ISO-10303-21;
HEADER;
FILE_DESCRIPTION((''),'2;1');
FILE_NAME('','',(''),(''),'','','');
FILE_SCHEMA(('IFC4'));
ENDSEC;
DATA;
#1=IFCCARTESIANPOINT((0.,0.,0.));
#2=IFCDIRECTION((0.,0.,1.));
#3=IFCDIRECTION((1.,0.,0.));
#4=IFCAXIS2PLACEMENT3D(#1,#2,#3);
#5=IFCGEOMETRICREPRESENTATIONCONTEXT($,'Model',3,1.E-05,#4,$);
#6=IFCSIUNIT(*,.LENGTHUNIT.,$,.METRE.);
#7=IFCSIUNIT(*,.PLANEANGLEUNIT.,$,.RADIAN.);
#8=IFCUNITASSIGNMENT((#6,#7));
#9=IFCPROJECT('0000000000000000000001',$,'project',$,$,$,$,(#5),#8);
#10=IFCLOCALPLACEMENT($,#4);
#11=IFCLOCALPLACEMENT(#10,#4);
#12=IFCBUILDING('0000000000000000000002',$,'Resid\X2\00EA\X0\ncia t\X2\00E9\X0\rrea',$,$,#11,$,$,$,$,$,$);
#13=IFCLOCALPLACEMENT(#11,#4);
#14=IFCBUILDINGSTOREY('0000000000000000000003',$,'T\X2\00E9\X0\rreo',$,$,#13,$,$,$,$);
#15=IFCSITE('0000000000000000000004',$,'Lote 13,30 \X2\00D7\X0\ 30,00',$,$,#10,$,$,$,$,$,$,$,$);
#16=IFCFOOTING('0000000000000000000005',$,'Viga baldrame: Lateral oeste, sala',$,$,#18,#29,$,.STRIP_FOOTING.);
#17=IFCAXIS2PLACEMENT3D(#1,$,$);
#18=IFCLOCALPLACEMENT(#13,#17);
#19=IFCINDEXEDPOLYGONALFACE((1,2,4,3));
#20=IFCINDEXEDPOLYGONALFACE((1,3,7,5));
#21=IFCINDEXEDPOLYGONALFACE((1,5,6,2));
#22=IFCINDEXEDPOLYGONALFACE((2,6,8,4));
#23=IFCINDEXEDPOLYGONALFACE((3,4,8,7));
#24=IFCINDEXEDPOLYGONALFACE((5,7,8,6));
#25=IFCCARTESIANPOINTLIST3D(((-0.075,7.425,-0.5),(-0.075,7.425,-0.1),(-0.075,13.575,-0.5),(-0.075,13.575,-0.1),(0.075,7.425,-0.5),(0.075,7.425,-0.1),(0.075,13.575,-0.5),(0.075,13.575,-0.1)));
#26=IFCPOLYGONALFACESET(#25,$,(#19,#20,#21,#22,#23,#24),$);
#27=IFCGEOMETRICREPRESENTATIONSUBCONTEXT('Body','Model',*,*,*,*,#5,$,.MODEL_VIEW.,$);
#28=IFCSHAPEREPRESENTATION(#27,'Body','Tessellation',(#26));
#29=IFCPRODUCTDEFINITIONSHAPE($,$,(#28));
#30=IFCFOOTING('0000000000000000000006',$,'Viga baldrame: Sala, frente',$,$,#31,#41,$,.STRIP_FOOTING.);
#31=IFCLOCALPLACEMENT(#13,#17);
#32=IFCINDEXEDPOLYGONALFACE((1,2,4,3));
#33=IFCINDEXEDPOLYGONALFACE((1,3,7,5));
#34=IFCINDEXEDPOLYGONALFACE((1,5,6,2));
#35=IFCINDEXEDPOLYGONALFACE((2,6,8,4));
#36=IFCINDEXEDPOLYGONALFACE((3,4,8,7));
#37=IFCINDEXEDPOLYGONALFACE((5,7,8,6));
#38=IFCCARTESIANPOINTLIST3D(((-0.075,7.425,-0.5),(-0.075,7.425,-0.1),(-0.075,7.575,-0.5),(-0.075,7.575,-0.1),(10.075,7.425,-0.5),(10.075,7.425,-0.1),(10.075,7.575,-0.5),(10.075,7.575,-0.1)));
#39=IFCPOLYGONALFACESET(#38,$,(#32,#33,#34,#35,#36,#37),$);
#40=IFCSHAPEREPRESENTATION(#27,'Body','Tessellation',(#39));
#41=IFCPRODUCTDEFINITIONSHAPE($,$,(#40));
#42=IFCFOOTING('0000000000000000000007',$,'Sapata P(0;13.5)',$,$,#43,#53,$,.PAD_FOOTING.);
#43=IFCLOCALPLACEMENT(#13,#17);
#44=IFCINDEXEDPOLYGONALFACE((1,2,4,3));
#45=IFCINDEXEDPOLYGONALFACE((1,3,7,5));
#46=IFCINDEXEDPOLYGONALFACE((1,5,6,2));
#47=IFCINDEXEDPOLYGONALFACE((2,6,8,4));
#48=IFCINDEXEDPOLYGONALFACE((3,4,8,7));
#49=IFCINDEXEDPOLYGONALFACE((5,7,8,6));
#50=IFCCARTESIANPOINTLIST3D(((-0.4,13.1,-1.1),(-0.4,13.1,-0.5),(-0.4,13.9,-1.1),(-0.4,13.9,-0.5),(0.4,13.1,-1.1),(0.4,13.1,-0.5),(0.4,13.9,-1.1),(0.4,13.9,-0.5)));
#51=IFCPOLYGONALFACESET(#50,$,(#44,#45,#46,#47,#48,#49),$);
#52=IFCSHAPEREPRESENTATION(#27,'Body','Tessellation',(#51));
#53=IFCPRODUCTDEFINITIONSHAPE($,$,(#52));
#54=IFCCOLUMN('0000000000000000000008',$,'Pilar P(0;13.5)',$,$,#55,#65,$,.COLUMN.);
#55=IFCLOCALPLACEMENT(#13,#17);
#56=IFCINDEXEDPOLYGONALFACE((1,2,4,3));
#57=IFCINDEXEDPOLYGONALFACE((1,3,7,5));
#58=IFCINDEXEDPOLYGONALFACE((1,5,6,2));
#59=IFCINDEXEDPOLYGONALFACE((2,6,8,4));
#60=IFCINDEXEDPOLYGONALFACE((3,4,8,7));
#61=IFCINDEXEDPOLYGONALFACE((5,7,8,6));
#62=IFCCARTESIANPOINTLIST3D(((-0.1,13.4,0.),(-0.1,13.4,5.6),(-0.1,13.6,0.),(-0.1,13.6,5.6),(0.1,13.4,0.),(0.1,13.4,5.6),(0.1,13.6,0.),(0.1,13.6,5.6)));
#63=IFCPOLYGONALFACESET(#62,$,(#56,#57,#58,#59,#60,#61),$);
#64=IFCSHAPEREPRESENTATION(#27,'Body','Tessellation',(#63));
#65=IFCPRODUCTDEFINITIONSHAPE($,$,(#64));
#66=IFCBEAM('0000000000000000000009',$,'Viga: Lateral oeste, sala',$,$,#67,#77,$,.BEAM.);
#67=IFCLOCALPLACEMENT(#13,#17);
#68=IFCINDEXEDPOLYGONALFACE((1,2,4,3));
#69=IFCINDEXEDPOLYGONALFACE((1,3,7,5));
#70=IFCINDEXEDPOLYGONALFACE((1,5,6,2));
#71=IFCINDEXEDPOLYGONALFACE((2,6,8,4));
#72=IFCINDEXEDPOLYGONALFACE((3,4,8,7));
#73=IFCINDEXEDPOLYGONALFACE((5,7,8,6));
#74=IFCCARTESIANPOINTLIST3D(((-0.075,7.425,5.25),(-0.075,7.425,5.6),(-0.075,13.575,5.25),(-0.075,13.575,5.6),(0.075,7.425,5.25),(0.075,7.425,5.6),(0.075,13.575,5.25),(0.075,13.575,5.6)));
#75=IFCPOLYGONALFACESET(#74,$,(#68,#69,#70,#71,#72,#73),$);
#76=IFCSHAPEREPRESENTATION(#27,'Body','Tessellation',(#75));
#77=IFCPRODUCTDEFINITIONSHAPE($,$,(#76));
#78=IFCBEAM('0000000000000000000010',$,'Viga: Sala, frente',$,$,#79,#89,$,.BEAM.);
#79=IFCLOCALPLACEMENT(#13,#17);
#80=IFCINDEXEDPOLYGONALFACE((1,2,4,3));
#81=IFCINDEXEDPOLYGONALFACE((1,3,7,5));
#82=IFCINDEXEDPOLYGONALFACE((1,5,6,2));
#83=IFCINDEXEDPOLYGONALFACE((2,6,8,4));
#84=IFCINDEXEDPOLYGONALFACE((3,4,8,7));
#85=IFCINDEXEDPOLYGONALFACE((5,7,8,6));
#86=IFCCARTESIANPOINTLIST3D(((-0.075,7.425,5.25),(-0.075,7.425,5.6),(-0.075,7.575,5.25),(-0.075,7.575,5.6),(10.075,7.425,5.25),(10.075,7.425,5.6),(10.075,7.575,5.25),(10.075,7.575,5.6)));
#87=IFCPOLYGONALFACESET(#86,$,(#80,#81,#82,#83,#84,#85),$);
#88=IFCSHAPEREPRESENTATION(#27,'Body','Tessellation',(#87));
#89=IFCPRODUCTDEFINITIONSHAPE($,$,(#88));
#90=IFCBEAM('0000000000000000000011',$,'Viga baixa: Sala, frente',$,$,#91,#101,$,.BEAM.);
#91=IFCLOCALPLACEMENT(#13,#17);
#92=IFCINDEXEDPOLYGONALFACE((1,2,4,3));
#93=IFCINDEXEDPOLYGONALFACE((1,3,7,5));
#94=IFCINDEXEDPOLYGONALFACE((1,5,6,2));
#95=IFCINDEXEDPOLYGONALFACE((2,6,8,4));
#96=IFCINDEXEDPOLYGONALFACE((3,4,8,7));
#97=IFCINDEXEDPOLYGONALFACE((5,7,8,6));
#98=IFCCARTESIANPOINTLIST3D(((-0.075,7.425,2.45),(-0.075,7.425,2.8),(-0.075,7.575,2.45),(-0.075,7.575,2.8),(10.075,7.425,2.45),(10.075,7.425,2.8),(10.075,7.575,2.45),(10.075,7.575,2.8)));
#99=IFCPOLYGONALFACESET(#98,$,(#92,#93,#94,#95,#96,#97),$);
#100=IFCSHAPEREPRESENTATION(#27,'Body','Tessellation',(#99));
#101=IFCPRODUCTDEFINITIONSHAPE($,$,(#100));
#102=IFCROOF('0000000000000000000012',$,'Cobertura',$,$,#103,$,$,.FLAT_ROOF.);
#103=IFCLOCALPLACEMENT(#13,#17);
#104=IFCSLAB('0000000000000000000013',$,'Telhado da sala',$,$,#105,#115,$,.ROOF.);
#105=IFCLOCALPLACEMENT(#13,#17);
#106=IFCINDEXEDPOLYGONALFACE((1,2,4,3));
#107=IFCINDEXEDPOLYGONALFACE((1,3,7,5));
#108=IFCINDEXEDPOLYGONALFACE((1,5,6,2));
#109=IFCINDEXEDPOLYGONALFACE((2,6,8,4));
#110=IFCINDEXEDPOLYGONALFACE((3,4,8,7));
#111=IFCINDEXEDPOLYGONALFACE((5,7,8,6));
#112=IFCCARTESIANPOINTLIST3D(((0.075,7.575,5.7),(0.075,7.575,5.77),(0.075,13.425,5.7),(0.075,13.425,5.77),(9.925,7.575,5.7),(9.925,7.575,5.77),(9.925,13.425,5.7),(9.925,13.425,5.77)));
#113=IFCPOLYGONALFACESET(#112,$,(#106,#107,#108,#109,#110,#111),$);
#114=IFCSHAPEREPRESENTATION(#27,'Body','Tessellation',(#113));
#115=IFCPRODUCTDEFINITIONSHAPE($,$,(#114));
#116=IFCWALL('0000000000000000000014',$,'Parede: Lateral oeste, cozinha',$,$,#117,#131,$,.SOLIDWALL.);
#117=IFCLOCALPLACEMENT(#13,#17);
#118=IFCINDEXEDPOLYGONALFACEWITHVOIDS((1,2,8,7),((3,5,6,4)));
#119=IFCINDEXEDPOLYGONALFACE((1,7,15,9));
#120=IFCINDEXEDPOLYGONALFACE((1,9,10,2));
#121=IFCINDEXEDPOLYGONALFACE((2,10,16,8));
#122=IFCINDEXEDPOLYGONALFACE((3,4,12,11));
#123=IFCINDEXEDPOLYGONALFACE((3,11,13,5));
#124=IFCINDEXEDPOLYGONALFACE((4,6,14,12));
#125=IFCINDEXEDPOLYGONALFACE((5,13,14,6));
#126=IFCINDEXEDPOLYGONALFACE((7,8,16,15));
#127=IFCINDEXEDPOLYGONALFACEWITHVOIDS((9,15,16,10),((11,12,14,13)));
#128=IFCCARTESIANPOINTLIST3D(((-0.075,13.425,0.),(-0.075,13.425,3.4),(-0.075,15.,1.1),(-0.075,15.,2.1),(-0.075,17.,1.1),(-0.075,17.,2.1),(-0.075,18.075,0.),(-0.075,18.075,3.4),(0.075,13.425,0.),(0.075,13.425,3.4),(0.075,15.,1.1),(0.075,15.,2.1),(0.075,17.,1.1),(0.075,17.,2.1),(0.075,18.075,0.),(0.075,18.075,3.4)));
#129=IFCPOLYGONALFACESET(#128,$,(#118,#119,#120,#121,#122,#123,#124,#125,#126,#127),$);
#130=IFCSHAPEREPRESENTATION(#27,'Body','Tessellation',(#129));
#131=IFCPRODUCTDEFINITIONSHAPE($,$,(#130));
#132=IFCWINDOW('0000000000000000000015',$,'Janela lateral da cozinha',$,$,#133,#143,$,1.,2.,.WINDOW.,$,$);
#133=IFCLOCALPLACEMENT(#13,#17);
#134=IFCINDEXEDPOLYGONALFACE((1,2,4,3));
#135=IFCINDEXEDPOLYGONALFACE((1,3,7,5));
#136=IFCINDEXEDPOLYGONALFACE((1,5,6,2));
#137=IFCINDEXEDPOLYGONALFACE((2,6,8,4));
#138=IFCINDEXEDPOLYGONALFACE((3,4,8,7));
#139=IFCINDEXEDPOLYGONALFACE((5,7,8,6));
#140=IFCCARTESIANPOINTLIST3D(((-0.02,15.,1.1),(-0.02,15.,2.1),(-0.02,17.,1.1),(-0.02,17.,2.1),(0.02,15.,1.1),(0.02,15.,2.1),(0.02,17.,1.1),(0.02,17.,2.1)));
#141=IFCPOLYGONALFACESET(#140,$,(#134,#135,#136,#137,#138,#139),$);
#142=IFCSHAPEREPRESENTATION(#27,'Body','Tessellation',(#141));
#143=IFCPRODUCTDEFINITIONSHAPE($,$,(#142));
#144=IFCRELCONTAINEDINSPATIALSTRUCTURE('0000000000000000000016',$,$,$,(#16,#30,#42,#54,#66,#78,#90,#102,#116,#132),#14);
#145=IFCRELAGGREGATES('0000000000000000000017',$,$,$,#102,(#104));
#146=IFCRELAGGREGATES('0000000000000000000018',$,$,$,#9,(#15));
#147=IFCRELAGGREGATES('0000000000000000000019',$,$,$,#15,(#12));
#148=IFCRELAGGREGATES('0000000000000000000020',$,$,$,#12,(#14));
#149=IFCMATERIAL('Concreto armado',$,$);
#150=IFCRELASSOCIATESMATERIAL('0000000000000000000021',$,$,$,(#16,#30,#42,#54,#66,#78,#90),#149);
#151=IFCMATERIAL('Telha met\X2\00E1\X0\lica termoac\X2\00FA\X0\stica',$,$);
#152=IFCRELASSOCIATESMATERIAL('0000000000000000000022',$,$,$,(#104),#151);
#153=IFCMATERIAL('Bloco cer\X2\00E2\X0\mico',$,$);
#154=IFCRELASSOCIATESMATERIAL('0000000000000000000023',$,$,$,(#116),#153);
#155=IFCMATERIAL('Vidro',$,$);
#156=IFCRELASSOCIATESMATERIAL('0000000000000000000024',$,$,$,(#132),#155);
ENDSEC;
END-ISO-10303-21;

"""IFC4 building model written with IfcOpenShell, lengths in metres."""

from ifc_helpers import new_model, si_unit, frame, origin_with_axes, place, context, subcontext, project, spatial, line, indexed_curve, outline, extrude, material, element, fill, aggregate, save


model = new_model("IFC4")

# Units and contexts
model_context = context("Model", 3, precision=1e-05, world=origin_with_axes())
body_context = subcontext(model_context, "Body", "Model", "MODEL_VIEW")
ifc_project = project(units=[si_unit("LENGTHUNIT", "METRE"), si_unit("PLANEANGLEUNIT", "RADIAN")], contexts=[model_context])

# Site, building, storey
site_placement = place(None, origin_with_axes())
site = spatial("IfcSite", under=ifc_project, at=site_placement, Name="Lote 13,30 × 30,00")
building_placement = place(site_placement, origin_with_axes())
building = spatial("IfcBuilding", under=site, at=building_placement, Name="Residência térrea")
storey_placement = place(building_placement, origin_with_axes())
storey = spatial("IfcBuildingStorey", under=building, at=storey_placement, Name="Térreo")

# Footings
ifc_material_1 = material(Name="Concreto armado")
footing_1_placement = place(storey_placement, frame((-0.075, 7.425, -0.5), z_axis=(0.0, 0.0, 1.0), x_axis=(1.0, 0.0, 0.0)))
element("IfcFooting", 1, at=footing_1_placement, inside=storey, material=ifc_material_1, Name="Viga baldrame: Lateral oeste, sala", PredefinedType="STRIP_FOOTING", context=body_context, shape_type="SweptSolid", body=[
    extrude(outline(indexed_curve([(0.0, 0.0), (0.15, 0.0), (0.15, 6.15), (0.0, 6.15)], segments=[line(1, 2, 3, 4, 1)])), origin_with_axes(), (0.0, 0.0, 1.0), 0.4),
])
footing_2_placement = place(storey_placement, frame((-0.075, 7.425, -0.5), z_axis=(0.0, 0.0, 1.0), x_axis=(1.0, 0.0, 0.0)))
element("IfcFooting", 2, at=footing_2_placement, inside=storey, material=ifc_material_1, Name="Viga baldrame: Sala, frente", PredefinedType="STRIP_FOOTING", context=body_context, shape_type="SweptSolid", body=[
    extrude(outline(indexed_curve([(0.0, 0.0), (10.15, 0.0), (10.15, 0.15), (0.0, 0.15)], segments=[line(1, 2, 3, 4, 1)])), origin_with_axes(), (0.0, 0.0, 1.0), 0.4),
])
footing_3_placement = place(storey_placement, frame((-0.4, 13.1, -1.1), z_axis=(0.0, 0.0, 1.0), x_axis=(1.0, 0.0, 0.0)))
element("IfcFooting", 3, at=footing_3_placement, inside=storey, material=ifc_material_1, Name="Sapata P(0;13.5)", PredefinedType="PAD_FOOTING", context=body_context, shape_type="SweptSolid", body=[
    extrude(outline(indexed_curve([(0.0, 0.0), (0.8, 0.0), (0.8, 0.8), (0.0, 0.8)], segments=[line(1, 2, 3, 4, 1)])), origin_with_axes(), (0.0, 0.0, 1.0), 0.6),
])

# Column
column_placement = place(storey_placement, frame((-0.1, 13.4, 0.0), z_axis=(0.0, 0.0, 1.0), x_axis=(1.0, 0.0, 0.0)))
element("IfcColumn", 4, at=column_placement, inside=storey, material=ifc_material_1, Name="Pilar P(0;13.5)", PredefinedType="COLUMN", context=body_context, shape_type="SweptSolid", body=[
    extrude(outline(indexed_curve([(0.0, 0.0), (0.2, 0.0), (0.2, 0.2), (0.0, 0.2)], segments=[line(1, 2, 3, 4, 1)])), origin_with_axes(), (0.0, 0.0, 1.0), 5.6),
])

# Beams
beam_1_placement = place(storey_placement, frame((-0.075, 7.425, 5.25), z_axis=(0.0, 0.0, 1.0), x_axis=(1.0, 0.0, 0.0)))
element("IfcBeam", 5, at=beam_1_placement, inside=storey, material=ifc_material_1, Name="Viga: Lateral oeste, sala", PredefinedType="BEAM", context=body_context, shape_type="SweptSolid", body=[
    extrude(outline(indexed_curve([(0.0, 0.0), (0.15, 0.0), (0.15, 6.15), (0.0, 6.15)], segments=[line(1, 2, 3, 4, 1)])), origin_with_axes(), (0.0, 0.0, 1.0), 0.35),
])
beam_2_placement = place(storey_placement, frame((-0.075, 7.425, 5.25), z_axis=(0.0, 0.0, 1.0), x_axis=(1.0, 0.0, 0.0)))
element("IfcBeam", 6, at=beam_2_placement, inside=storey, material=ifc_material_1, Name="Viga: Sala, frente", PredefinedType="BEAM", context=body_context, shape_type="SweptSolid", body=[
    extrude(outline(indexed_curve([(0.0, 0.0), (10.15, 0.0), (10.15, 0.15), (0.0, 0.15)], segments=[line(1, 2, 3, 4, 1)])), origin_with_axes(), (0.0, 0.0, 1.0), 0.35),
])
beam_3_placement = place(storey_placement, frame((-0.075, 7.425, 2.45), z_axis=(0.0, 0.0, 1.0), x_axis=(1.0, 0.0, 0.0)))
element("IfcBeam", 7, at=beam_3_placement, inside=storey, material=ifc_material_1, Name="Viga baixa: Sala, frente", PredefinedType="BEAM", context=body_context, shape_type="SweptSolid", body=[
    extrude(outline(indexed_curve([(0.0, 0.0), (10.15, 0.0), (10.15, 0.15), (0.0, 0.15)], segments=[line(1, 2, 3, 4, 1)])), origin_with_axes(), (0.0, 0.0, 1.0), 0.35),
])

# Roof, slab
roof_placement = place(storey_placement, origin_with_axes())
roof = element("IfcRoof", 8, at=roof_placement, inside=storey, Name="Cobertura", PredefinedType="FLAT_ROOF")
ifc_material_2 = material(Name="Telha metálica termoacústica")
slab_placement = place(roof_placement, frame((0.075, 7.575, 5.7), z_axis=(0.0, 0.0, 1.0), x_axis=(1.0, 0.0, 0.0)))
slab = element("IfcSlab", 9, at=slab_placement, material=ifc_material_2, Name="Telhado da sala", PredefinedType="ROOF", context=body_context, shape_type="SweptSolid", body=[
    extrude(outline(indexed_curve([(0.0, 0.0), (9.85, 0.0), (9.85, 5.85), (0.0, 5.85)], segments=[line(1, 2, 3, 4, 1)])), origin_with_axes(), (0.0, 0.0, 1.0), 0.07),
])
aggregate(roof, [slab])

# Wall, opening, window
ifc_material_3 = material(Name="Bloco cerâmico")
wall_1_placement = place(storey_placement, frame((-0.075, 13.425, 0.0), z_axis=(0.0, 0.0, 1.0), x_axis=(1.0, 0.0, 0.0)))
wall_1 = element("IfcWall", 10, at=wall_1_placement, inside=storey, material=ifc_material_3, Name="Parede: Lateral oeste, cozinha", PredefinedType="SOLIDWALL", context=body_context, shape_type="SweptSolid", body=[
    extrude(outline(indexed_curve([(0.0, 0.0), (0.15, 0.0), (0.15, 4.65), (0.0, 4.65)], segments=[line(1, 2, 3, 4, 1)])), origin_with_axes(), (0.0, 0.0, 1.0), 3.4),
])
opening_1_placement = place(wall_1_placement, frame((-0.05, 1.575, 1.1), z_axis=(0.0, 0.0, 1.0), x_axis=(1.0, 0.0, 0.0)))
opening_1 = element("IfcOpeningElement", 11, at=opening_1_placement, cuts=wall_1, material=ifc_material_1, PredefinedType="OPENING", context=body_context, shape_type="SweptSolid", body=[
    extrude(outline(indexed_curve([(0.0, 0.0), (0.25, 0.0), (0.25, 2.0), (0.0, 2.0)], segments=[line(1, 2, 3, 4, 1)])), origin_with_axes(), (0.0, 0.0, 1.0), 1.0),
])
ifc_material_4 = material(Name="Vidro")
window_1_placement = place(storey_placement, frame((-0.02, 15.0, 1.1), z_axis=(0.0, 0.0, 1.0), x_axis=(1.0, 0.0, 0.0)))
window_1 = element("IfcWindow", 12, at=window_1_placement, inside=storey, material=ifc_material_4, Name="Janela lateral da cozinha", OverallHeight=1.0, OverallWidth=2.0, PredefinedType="WINDOW", context=body_context, shape_type="SweptSolid", body=[
    extrude(outline(indexed_curve([(0.0, 0.0), (0.04, 0.0), (0.04, 2.0), (0.0, 2.0)], segments=[line(1, 2, 3, 4, 1)])), origin_with_axes(), (0.0, 0.0, 1.0), 1.0),
])
fill(opening_1, window_1)

save(model, "model.ifc")
